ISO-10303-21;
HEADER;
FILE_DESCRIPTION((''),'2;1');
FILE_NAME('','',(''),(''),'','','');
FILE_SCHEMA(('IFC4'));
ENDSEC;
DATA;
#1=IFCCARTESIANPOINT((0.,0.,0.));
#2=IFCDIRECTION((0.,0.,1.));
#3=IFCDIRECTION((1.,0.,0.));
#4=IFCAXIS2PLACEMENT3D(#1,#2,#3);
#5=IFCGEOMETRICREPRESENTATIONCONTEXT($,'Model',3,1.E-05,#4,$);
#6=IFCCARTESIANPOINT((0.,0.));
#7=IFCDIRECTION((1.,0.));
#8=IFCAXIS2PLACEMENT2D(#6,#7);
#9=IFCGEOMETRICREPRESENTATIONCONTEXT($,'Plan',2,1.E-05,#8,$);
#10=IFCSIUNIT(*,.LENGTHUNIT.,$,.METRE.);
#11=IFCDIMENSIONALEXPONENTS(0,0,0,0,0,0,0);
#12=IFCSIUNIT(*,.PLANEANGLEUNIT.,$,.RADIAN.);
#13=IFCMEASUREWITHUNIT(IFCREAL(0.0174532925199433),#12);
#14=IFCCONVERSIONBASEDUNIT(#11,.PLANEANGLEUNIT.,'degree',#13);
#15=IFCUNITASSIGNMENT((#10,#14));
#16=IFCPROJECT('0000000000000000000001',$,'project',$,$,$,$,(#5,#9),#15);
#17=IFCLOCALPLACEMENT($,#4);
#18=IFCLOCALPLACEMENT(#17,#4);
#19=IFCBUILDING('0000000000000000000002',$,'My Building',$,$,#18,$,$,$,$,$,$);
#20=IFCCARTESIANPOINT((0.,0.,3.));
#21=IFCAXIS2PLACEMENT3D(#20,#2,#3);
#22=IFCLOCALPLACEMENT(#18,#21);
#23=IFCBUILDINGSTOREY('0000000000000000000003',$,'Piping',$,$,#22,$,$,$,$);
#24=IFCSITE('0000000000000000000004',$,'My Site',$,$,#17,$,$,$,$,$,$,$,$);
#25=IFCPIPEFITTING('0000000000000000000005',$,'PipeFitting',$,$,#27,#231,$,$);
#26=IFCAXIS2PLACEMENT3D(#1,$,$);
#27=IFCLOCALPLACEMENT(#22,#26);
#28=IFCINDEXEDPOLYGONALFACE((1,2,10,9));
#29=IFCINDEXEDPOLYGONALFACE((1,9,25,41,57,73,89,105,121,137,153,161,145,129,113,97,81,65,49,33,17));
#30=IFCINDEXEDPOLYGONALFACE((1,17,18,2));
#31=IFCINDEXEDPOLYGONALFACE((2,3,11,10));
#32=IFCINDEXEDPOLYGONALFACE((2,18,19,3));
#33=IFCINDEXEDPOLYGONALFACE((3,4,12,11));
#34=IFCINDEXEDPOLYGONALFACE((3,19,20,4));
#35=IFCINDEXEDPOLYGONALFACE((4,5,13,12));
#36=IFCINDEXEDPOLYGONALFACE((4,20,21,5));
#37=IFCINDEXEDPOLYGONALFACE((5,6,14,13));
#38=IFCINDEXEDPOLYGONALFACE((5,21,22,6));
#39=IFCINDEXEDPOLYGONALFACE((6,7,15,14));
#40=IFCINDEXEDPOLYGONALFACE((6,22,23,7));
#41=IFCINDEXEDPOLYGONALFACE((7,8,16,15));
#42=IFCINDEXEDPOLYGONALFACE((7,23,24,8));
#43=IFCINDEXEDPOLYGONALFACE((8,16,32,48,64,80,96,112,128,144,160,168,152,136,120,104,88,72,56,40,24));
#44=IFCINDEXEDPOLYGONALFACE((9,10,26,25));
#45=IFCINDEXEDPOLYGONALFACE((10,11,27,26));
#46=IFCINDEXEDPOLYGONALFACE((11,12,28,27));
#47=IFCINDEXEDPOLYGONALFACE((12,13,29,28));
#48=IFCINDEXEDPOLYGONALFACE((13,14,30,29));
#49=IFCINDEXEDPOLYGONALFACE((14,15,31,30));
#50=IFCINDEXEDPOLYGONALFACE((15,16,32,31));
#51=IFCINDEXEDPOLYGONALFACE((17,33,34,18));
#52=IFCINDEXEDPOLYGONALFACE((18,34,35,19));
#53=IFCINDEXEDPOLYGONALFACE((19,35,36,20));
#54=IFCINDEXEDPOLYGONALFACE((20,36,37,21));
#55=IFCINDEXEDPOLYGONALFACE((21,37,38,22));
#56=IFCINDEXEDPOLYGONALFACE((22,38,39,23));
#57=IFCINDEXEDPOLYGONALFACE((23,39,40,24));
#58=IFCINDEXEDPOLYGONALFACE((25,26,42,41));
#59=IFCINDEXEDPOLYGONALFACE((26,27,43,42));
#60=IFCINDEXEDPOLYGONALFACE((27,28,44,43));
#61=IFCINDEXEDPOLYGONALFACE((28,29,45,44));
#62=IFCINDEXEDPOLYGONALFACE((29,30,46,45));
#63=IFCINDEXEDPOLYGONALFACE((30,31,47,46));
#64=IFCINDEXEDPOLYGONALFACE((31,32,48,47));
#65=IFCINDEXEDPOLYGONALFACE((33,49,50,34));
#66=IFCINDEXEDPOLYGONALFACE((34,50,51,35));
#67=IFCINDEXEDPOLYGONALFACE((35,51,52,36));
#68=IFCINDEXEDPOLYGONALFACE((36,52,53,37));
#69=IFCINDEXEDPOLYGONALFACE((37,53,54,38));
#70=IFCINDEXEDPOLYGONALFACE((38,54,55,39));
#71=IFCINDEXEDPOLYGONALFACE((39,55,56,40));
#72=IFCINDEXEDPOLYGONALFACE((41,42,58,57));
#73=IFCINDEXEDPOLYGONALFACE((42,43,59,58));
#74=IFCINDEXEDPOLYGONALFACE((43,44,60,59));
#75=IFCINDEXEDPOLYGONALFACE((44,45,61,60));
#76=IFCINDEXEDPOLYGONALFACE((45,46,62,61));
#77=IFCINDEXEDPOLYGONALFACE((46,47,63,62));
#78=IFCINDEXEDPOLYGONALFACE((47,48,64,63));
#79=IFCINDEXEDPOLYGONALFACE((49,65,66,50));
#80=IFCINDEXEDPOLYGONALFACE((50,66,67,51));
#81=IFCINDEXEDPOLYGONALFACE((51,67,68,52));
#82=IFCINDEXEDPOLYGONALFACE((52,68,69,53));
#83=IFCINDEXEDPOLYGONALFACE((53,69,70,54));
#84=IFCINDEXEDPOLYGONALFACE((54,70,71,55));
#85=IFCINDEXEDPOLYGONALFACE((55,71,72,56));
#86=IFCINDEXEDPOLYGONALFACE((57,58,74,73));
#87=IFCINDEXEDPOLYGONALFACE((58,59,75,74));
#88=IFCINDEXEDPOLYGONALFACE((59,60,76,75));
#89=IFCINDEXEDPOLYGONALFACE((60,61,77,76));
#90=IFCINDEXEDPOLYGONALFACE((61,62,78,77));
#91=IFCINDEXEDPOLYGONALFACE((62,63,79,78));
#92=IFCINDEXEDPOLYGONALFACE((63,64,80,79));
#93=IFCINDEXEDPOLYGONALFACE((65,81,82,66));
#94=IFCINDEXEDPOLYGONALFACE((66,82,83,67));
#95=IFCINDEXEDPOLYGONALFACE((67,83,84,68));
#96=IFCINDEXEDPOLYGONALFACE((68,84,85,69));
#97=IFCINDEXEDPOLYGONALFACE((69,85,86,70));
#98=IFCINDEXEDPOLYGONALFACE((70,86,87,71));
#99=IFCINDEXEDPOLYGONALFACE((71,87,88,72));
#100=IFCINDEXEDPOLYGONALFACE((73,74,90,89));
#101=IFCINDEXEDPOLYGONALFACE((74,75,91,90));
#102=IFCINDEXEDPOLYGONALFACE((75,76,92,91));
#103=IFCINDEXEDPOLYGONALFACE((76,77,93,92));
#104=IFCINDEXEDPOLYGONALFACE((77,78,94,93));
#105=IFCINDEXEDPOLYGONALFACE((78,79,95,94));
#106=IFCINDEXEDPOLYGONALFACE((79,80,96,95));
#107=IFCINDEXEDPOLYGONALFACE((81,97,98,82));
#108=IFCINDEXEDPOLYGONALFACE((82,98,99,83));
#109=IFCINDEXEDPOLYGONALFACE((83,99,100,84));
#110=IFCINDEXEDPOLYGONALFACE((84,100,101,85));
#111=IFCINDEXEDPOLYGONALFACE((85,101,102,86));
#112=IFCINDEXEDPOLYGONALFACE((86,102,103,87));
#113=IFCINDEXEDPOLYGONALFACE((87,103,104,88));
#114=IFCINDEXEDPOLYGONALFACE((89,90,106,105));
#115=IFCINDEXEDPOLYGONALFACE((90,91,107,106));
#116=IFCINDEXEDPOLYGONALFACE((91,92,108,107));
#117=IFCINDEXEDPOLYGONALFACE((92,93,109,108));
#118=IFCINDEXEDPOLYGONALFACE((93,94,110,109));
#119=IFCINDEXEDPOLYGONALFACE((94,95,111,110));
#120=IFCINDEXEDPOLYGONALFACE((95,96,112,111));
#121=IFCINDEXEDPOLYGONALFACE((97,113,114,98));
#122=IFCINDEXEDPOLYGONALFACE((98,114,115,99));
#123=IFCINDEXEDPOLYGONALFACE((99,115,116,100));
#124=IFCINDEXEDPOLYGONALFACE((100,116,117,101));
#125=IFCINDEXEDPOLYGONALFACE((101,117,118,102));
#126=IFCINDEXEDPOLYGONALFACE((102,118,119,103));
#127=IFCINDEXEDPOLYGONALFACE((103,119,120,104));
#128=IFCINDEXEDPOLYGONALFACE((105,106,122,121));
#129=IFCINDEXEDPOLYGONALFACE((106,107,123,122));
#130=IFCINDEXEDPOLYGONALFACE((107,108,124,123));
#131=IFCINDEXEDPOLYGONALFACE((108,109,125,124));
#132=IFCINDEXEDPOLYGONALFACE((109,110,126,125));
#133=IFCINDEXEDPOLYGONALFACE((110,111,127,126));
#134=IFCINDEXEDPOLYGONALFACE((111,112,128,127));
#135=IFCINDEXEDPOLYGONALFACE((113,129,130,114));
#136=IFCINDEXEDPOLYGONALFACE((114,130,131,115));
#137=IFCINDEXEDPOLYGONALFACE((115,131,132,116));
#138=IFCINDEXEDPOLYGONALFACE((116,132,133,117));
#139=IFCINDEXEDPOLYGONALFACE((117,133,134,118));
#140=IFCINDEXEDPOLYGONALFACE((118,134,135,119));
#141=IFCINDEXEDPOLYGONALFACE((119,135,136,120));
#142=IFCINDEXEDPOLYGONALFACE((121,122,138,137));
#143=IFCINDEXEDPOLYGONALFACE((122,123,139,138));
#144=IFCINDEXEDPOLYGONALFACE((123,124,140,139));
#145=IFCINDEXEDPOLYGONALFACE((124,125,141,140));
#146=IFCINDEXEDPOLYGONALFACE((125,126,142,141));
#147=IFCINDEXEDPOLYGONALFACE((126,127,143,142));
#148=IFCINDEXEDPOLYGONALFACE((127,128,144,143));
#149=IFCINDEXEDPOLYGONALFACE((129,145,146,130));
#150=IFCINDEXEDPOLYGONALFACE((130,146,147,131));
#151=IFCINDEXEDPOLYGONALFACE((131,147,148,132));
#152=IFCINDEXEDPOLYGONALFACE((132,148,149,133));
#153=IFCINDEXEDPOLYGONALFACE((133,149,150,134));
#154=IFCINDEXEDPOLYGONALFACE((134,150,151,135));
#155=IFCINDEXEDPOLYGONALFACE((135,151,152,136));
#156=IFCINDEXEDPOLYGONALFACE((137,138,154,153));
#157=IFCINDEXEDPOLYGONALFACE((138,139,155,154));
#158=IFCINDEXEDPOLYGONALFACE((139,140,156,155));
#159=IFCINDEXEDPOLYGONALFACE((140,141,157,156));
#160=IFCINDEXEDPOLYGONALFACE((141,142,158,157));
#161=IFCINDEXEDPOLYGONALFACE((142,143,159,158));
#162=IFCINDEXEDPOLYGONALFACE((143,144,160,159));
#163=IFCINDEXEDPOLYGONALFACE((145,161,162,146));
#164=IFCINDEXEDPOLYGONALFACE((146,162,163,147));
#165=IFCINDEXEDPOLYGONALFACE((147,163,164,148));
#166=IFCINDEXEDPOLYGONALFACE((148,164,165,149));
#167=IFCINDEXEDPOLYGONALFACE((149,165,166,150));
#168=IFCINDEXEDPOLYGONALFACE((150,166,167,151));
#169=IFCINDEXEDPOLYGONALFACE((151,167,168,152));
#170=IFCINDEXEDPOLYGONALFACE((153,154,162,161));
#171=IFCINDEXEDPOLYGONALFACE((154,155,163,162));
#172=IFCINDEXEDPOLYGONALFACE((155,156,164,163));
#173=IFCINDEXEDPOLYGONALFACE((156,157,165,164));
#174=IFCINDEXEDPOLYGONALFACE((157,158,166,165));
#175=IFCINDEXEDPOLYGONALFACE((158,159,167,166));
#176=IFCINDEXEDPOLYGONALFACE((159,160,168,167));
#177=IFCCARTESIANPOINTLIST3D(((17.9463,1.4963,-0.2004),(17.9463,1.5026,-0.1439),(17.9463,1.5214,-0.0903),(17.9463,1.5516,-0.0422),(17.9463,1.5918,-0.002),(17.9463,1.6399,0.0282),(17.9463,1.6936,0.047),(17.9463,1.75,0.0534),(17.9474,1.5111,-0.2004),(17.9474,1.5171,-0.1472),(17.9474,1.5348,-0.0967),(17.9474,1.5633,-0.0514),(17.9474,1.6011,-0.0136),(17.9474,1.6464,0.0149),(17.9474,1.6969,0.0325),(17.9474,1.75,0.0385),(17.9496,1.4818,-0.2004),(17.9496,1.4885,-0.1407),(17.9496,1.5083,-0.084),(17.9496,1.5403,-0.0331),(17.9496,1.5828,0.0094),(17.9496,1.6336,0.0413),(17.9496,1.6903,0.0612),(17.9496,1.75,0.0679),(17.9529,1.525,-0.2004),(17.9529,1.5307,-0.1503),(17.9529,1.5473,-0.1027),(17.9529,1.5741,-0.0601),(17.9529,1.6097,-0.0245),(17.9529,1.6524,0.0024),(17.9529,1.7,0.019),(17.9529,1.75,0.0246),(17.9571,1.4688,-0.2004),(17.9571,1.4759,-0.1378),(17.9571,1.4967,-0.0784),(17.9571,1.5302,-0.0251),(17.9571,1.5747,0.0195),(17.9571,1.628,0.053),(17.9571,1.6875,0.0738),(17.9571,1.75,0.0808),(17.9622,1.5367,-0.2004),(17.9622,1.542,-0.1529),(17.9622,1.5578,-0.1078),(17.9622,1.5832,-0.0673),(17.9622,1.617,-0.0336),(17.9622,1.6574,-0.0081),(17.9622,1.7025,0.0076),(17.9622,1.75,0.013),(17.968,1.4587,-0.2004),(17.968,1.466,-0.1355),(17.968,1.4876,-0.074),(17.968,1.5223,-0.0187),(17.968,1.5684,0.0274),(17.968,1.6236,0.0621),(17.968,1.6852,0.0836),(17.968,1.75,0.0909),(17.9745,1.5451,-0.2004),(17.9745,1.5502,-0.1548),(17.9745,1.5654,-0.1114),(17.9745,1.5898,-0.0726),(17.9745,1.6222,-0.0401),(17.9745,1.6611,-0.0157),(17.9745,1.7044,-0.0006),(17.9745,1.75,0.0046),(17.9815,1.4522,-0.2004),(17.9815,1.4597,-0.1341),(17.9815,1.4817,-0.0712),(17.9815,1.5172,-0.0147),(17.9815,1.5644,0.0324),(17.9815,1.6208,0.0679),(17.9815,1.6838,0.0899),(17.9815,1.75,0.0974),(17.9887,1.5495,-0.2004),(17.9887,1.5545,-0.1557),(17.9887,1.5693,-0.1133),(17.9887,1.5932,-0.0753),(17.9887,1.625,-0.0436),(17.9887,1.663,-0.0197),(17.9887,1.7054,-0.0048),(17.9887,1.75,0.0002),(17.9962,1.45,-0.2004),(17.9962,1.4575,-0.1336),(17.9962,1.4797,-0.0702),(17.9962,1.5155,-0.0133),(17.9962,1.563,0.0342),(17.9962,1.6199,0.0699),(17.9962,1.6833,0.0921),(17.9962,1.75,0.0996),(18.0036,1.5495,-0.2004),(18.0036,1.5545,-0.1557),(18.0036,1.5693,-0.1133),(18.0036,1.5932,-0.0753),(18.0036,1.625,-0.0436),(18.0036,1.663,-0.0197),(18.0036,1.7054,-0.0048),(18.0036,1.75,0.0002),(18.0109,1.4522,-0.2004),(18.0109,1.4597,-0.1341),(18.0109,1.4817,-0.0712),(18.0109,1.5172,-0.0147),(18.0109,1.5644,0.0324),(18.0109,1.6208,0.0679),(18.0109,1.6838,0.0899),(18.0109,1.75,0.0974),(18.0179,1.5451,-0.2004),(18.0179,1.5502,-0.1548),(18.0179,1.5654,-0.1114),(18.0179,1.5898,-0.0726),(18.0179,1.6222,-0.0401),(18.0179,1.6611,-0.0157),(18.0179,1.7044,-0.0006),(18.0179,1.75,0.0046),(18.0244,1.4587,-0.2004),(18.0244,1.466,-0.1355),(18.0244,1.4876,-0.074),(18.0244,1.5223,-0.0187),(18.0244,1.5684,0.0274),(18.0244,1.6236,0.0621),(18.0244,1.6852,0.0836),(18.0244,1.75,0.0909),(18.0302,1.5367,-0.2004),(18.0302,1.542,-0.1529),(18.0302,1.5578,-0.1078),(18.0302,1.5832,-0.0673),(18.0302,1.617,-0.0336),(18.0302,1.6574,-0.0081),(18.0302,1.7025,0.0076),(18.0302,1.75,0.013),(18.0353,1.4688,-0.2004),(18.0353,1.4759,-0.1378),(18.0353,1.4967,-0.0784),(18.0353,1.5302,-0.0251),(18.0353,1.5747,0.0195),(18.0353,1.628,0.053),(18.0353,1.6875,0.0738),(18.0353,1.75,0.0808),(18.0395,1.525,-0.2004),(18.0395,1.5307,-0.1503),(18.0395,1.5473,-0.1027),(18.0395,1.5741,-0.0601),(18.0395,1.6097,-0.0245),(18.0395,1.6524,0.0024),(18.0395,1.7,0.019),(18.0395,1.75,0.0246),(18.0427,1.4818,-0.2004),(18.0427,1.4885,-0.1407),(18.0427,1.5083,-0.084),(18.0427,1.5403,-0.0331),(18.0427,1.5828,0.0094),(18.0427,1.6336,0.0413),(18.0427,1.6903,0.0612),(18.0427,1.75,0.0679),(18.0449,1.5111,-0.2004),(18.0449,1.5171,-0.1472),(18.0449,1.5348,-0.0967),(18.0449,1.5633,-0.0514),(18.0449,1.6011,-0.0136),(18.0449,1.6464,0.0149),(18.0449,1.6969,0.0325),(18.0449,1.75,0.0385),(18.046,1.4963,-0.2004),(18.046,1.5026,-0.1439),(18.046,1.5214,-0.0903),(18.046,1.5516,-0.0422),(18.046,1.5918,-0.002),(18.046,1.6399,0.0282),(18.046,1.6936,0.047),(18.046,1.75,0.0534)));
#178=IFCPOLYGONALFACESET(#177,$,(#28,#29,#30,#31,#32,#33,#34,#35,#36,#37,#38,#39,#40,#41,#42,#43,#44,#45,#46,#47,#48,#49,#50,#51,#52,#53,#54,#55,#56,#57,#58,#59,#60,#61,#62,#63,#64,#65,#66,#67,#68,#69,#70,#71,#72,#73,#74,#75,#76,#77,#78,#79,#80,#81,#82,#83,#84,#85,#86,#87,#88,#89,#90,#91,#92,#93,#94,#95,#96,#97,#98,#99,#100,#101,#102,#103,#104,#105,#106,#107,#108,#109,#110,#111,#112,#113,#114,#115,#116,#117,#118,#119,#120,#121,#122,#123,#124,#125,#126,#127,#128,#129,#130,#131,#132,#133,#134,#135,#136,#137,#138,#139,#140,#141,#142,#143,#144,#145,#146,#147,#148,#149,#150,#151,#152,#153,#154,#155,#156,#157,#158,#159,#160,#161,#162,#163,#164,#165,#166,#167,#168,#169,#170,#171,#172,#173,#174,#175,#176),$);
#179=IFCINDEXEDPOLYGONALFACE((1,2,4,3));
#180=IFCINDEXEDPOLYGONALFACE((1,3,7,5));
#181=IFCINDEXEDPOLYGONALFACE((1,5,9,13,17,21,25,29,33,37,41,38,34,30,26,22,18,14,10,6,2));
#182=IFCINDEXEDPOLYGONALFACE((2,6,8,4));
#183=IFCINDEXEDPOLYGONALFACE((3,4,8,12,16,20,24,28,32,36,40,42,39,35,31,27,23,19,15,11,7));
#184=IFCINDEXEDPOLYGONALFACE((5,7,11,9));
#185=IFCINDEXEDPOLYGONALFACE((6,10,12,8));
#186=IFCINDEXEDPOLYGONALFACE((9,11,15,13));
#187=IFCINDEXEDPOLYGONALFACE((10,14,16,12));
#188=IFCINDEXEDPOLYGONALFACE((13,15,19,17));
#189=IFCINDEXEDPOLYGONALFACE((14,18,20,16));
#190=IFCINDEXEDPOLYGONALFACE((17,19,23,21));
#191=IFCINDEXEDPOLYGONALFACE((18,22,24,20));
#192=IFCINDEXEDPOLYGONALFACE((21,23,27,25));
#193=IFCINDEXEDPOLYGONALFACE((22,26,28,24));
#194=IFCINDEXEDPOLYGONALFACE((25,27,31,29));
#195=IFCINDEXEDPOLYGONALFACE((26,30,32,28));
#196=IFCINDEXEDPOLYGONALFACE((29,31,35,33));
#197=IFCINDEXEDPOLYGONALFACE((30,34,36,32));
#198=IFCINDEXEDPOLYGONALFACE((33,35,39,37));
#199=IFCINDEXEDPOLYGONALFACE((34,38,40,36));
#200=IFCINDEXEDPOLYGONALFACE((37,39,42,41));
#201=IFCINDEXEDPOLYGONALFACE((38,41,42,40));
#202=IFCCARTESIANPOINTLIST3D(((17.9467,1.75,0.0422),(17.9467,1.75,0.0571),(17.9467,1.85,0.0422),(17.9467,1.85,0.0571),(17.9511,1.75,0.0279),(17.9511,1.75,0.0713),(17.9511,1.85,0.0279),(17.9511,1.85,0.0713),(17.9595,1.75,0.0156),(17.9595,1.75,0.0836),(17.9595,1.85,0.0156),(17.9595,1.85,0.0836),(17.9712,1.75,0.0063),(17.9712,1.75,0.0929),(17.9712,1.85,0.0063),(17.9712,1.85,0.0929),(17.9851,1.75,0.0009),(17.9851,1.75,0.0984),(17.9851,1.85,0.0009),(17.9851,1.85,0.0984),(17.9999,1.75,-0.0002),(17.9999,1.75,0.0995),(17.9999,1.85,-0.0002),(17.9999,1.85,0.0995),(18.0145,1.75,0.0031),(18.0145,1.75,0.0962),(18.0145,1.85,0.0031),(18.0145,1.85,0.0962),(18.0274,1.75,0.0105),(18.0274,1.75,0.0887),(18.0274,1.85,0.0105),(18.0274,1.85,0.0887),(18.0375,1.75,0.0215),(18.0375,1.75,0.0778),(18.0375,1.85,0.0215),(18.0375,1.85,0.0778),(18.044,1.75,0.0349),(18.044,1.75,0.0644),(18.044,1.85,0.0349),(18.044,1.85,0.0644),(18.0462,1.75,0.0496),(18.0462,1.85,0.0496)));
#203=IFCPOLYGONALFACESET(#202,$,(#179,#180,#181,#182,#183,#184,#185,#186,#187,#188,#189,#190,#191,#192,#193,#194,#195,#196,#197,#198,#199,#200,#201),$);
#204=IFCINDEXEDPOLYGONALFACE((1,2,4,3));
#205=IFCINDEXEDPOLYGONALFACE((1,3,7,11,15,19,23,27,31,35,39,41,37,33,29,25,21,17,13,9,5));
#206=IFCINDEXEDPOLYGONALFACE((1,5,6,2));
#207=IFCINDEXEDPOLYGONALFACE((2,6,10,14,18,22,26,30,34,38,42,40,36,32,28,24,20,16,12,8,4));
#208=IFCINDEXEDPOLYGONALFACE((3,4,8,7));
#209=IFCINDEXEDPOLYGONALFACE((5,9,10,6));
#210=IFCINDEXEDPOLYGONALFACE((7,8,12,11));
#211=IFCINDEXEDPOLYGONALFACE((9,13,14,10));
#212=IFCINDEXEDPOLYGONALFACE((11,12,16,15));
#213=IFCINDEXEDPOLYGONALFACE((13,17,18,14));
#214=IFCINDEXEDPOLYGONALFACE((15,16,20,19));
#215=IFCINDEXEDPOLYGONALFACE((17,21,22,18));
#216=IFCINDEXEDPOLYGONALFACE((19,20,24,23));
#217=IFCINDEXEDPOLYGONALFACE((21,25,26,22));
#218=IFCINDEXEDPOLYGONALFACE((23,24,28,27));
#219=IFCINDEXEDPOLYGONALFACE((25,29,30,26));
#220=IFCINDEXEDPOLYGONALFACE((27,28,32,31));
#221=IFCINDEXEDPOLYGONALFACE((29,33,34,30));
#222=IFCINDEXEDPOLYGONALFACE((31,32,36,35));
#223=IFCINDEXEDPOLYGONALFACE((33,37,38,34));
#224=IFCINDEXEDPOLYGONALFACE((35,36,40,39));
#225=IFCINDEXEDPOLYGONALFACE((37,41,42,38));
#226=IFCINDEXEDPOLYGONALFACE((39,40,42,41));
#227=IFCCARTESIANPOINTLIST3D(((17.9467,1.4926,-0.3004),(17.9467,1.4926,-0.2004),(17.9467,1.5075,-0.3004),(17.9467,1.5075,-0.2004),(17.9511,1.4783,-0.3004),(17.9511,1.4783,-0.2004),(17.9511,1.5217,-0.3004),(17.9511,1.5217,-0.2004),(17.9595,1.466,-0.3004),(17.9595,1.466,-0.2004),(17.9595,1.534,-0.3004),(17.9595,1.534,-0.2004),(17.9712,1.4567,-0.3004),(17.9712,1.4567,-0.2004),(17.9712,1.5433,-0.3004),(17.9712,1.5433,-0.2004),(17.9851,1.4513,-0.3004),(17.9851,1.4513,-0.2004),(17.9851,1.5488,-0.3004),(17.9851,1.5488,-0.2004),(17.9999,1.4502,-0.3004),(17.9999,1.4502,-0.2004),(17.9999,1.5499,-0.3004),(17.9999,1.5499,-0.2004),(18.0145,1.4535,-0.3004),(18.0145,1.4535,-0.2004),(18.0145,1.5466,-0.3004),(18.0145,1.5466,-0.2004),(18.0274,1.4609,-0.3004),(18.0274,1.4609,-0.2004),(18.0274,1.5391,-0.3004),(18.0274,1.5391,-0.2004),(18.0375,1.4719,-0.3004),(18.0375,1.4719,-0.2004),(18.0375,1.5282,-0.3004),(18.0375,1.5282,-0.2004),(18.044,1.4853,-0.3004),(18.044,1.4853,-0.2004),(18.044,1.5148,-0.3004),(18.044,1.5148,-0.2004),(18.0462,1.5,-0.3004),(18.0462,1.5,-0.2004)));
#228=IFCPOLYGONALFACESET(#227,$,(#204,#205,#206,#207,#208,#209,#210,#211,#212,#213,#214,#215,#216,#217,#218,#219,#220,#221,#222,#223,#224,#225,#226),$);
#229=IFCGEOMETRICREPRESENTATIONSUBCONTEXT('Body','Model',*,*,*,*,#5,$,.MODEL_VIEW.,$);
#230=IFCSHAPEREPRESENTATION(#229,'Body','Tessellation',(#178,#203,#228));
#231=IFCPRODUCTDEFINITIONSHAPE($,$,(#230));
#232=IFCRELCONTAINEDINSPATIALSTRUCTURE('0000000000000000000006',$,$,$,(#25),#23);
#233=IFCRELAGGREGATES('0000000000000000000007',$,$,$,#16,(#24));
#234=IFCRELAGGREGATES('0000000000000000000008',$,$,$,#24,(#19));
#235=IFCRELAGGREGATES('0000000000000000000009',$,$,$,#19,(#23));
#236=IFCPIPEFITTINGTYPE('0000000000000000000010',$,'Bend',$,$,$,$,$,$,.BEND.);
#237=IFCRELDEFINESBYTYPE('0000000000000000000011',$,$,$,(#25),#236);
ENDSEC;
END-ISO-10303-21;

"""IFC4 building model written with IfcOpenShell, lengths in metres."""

from ifc_helpers import new_model, entity, si_unit, converted_unit, frame, origin_with_axes, origin_2d_with_axis, place, context, subcontext, project, spatial, circle, extrude, source, transform, mapped, type_object, type_shapes, element, save


model = new_model("IFC4")

# Units and contexts
model_context = context("Model", 3, precision=1e-05, world=origin_with_axes())
plan_context = context("Plan", 2, precision=1e-05, world=origin_2d_with_axis())
body_context = subcontext(model_context, "Body", "Model", "MODEL_VIEW")
ifc_project = project(units=[si_unit("LENGTHUNIT", "METRE"), converted_unit("PLANEANGLEUNIT", "degree", entity("IfcReal", 0.0174532925199433), si_unit("PLANEANGLEUNIT", "RADIAN"), dimensions=[0, 0, 0, 0, 0, 0, 0])], contexts=[model_context, plan_context])

# Site, building, storey
site_placement = place(None, origin_with_axes())
site = spatial("IfcSite", under=ifc_project, at=site_placement, Name="My Site")
building_placement = place(site_placement, origin_with_axes())
building = spatial("IfcBuilding", under=site, at=building_placement, Name="My Building")
storey_placement = place(building_placement, frame((0.0, 0.0, 3.0), z_axis=(0.0, 0.0, 1.0), x_axis=(1.0, 0.0, 0.0)))
storey = spatial("IfcBuildingStorey", under=building, at=storey_placement, Name="Piping")

# Pipe fitting
pipe_fitting_type_1 = type_object("IfcPipeFittingType", Name="Bend", PredefinedType="BEND")
shared_shape = source(origin_with_axes(), body_context, "Body", "SolidModel", [
    entity("IfcSweptDiskSolid", entity("IfcIndexedPolyCurve", entity("IfcCartesianPointList3D", [[0.0, 0.0, 0.1], [0.0, -0.0732, 0.2768], [0.0, -0.25, 0.35]]), [entity("IfcArcIndex", [1, 2, 3])]), 0.05),
    extrude(circle(Radius=0.05), origin_with_axes(), (0.0, 0.0, 1.0), 0.1),
    extrude(circle(Radius=0.05), frame((0.0, -0.25, 0.35), z_axis=(0.0, -1.0, 0.0), x_axis=(1.0, 0.0, 0.0)), (0.0, 0.0, 1.0), 0.1),
])
type_shapes(pipe_fitting_type_1, [shared_shape])
for number, where, z_axis, x_axis, name in (
    (1, (17.9962, 1.85, 0.0496), (0.0, -1.0, 0.0), (1.0, 0.0, 0.0), "PipeFitting"),
):
    element("IfcPipeFitting", number, at=place(storey_placement, frame(where, z_axis=z_axis, x_axis=x_axis)), inside=storey, type_object=pipe_fitting_type_1, Name=name, context=body_context, shape_type="MappedRepresentation", body=[
        mapped(shared_shape, transform((0.0, 0.0, 0.0), x_axis=(1.0, 0.0, 0.0), y_axis=(0.0, 1.0, 0.0), z_axis=(0.0, 0.0, 1.0), scale=1.0)),
    ])

save(model, "model.ifc")
